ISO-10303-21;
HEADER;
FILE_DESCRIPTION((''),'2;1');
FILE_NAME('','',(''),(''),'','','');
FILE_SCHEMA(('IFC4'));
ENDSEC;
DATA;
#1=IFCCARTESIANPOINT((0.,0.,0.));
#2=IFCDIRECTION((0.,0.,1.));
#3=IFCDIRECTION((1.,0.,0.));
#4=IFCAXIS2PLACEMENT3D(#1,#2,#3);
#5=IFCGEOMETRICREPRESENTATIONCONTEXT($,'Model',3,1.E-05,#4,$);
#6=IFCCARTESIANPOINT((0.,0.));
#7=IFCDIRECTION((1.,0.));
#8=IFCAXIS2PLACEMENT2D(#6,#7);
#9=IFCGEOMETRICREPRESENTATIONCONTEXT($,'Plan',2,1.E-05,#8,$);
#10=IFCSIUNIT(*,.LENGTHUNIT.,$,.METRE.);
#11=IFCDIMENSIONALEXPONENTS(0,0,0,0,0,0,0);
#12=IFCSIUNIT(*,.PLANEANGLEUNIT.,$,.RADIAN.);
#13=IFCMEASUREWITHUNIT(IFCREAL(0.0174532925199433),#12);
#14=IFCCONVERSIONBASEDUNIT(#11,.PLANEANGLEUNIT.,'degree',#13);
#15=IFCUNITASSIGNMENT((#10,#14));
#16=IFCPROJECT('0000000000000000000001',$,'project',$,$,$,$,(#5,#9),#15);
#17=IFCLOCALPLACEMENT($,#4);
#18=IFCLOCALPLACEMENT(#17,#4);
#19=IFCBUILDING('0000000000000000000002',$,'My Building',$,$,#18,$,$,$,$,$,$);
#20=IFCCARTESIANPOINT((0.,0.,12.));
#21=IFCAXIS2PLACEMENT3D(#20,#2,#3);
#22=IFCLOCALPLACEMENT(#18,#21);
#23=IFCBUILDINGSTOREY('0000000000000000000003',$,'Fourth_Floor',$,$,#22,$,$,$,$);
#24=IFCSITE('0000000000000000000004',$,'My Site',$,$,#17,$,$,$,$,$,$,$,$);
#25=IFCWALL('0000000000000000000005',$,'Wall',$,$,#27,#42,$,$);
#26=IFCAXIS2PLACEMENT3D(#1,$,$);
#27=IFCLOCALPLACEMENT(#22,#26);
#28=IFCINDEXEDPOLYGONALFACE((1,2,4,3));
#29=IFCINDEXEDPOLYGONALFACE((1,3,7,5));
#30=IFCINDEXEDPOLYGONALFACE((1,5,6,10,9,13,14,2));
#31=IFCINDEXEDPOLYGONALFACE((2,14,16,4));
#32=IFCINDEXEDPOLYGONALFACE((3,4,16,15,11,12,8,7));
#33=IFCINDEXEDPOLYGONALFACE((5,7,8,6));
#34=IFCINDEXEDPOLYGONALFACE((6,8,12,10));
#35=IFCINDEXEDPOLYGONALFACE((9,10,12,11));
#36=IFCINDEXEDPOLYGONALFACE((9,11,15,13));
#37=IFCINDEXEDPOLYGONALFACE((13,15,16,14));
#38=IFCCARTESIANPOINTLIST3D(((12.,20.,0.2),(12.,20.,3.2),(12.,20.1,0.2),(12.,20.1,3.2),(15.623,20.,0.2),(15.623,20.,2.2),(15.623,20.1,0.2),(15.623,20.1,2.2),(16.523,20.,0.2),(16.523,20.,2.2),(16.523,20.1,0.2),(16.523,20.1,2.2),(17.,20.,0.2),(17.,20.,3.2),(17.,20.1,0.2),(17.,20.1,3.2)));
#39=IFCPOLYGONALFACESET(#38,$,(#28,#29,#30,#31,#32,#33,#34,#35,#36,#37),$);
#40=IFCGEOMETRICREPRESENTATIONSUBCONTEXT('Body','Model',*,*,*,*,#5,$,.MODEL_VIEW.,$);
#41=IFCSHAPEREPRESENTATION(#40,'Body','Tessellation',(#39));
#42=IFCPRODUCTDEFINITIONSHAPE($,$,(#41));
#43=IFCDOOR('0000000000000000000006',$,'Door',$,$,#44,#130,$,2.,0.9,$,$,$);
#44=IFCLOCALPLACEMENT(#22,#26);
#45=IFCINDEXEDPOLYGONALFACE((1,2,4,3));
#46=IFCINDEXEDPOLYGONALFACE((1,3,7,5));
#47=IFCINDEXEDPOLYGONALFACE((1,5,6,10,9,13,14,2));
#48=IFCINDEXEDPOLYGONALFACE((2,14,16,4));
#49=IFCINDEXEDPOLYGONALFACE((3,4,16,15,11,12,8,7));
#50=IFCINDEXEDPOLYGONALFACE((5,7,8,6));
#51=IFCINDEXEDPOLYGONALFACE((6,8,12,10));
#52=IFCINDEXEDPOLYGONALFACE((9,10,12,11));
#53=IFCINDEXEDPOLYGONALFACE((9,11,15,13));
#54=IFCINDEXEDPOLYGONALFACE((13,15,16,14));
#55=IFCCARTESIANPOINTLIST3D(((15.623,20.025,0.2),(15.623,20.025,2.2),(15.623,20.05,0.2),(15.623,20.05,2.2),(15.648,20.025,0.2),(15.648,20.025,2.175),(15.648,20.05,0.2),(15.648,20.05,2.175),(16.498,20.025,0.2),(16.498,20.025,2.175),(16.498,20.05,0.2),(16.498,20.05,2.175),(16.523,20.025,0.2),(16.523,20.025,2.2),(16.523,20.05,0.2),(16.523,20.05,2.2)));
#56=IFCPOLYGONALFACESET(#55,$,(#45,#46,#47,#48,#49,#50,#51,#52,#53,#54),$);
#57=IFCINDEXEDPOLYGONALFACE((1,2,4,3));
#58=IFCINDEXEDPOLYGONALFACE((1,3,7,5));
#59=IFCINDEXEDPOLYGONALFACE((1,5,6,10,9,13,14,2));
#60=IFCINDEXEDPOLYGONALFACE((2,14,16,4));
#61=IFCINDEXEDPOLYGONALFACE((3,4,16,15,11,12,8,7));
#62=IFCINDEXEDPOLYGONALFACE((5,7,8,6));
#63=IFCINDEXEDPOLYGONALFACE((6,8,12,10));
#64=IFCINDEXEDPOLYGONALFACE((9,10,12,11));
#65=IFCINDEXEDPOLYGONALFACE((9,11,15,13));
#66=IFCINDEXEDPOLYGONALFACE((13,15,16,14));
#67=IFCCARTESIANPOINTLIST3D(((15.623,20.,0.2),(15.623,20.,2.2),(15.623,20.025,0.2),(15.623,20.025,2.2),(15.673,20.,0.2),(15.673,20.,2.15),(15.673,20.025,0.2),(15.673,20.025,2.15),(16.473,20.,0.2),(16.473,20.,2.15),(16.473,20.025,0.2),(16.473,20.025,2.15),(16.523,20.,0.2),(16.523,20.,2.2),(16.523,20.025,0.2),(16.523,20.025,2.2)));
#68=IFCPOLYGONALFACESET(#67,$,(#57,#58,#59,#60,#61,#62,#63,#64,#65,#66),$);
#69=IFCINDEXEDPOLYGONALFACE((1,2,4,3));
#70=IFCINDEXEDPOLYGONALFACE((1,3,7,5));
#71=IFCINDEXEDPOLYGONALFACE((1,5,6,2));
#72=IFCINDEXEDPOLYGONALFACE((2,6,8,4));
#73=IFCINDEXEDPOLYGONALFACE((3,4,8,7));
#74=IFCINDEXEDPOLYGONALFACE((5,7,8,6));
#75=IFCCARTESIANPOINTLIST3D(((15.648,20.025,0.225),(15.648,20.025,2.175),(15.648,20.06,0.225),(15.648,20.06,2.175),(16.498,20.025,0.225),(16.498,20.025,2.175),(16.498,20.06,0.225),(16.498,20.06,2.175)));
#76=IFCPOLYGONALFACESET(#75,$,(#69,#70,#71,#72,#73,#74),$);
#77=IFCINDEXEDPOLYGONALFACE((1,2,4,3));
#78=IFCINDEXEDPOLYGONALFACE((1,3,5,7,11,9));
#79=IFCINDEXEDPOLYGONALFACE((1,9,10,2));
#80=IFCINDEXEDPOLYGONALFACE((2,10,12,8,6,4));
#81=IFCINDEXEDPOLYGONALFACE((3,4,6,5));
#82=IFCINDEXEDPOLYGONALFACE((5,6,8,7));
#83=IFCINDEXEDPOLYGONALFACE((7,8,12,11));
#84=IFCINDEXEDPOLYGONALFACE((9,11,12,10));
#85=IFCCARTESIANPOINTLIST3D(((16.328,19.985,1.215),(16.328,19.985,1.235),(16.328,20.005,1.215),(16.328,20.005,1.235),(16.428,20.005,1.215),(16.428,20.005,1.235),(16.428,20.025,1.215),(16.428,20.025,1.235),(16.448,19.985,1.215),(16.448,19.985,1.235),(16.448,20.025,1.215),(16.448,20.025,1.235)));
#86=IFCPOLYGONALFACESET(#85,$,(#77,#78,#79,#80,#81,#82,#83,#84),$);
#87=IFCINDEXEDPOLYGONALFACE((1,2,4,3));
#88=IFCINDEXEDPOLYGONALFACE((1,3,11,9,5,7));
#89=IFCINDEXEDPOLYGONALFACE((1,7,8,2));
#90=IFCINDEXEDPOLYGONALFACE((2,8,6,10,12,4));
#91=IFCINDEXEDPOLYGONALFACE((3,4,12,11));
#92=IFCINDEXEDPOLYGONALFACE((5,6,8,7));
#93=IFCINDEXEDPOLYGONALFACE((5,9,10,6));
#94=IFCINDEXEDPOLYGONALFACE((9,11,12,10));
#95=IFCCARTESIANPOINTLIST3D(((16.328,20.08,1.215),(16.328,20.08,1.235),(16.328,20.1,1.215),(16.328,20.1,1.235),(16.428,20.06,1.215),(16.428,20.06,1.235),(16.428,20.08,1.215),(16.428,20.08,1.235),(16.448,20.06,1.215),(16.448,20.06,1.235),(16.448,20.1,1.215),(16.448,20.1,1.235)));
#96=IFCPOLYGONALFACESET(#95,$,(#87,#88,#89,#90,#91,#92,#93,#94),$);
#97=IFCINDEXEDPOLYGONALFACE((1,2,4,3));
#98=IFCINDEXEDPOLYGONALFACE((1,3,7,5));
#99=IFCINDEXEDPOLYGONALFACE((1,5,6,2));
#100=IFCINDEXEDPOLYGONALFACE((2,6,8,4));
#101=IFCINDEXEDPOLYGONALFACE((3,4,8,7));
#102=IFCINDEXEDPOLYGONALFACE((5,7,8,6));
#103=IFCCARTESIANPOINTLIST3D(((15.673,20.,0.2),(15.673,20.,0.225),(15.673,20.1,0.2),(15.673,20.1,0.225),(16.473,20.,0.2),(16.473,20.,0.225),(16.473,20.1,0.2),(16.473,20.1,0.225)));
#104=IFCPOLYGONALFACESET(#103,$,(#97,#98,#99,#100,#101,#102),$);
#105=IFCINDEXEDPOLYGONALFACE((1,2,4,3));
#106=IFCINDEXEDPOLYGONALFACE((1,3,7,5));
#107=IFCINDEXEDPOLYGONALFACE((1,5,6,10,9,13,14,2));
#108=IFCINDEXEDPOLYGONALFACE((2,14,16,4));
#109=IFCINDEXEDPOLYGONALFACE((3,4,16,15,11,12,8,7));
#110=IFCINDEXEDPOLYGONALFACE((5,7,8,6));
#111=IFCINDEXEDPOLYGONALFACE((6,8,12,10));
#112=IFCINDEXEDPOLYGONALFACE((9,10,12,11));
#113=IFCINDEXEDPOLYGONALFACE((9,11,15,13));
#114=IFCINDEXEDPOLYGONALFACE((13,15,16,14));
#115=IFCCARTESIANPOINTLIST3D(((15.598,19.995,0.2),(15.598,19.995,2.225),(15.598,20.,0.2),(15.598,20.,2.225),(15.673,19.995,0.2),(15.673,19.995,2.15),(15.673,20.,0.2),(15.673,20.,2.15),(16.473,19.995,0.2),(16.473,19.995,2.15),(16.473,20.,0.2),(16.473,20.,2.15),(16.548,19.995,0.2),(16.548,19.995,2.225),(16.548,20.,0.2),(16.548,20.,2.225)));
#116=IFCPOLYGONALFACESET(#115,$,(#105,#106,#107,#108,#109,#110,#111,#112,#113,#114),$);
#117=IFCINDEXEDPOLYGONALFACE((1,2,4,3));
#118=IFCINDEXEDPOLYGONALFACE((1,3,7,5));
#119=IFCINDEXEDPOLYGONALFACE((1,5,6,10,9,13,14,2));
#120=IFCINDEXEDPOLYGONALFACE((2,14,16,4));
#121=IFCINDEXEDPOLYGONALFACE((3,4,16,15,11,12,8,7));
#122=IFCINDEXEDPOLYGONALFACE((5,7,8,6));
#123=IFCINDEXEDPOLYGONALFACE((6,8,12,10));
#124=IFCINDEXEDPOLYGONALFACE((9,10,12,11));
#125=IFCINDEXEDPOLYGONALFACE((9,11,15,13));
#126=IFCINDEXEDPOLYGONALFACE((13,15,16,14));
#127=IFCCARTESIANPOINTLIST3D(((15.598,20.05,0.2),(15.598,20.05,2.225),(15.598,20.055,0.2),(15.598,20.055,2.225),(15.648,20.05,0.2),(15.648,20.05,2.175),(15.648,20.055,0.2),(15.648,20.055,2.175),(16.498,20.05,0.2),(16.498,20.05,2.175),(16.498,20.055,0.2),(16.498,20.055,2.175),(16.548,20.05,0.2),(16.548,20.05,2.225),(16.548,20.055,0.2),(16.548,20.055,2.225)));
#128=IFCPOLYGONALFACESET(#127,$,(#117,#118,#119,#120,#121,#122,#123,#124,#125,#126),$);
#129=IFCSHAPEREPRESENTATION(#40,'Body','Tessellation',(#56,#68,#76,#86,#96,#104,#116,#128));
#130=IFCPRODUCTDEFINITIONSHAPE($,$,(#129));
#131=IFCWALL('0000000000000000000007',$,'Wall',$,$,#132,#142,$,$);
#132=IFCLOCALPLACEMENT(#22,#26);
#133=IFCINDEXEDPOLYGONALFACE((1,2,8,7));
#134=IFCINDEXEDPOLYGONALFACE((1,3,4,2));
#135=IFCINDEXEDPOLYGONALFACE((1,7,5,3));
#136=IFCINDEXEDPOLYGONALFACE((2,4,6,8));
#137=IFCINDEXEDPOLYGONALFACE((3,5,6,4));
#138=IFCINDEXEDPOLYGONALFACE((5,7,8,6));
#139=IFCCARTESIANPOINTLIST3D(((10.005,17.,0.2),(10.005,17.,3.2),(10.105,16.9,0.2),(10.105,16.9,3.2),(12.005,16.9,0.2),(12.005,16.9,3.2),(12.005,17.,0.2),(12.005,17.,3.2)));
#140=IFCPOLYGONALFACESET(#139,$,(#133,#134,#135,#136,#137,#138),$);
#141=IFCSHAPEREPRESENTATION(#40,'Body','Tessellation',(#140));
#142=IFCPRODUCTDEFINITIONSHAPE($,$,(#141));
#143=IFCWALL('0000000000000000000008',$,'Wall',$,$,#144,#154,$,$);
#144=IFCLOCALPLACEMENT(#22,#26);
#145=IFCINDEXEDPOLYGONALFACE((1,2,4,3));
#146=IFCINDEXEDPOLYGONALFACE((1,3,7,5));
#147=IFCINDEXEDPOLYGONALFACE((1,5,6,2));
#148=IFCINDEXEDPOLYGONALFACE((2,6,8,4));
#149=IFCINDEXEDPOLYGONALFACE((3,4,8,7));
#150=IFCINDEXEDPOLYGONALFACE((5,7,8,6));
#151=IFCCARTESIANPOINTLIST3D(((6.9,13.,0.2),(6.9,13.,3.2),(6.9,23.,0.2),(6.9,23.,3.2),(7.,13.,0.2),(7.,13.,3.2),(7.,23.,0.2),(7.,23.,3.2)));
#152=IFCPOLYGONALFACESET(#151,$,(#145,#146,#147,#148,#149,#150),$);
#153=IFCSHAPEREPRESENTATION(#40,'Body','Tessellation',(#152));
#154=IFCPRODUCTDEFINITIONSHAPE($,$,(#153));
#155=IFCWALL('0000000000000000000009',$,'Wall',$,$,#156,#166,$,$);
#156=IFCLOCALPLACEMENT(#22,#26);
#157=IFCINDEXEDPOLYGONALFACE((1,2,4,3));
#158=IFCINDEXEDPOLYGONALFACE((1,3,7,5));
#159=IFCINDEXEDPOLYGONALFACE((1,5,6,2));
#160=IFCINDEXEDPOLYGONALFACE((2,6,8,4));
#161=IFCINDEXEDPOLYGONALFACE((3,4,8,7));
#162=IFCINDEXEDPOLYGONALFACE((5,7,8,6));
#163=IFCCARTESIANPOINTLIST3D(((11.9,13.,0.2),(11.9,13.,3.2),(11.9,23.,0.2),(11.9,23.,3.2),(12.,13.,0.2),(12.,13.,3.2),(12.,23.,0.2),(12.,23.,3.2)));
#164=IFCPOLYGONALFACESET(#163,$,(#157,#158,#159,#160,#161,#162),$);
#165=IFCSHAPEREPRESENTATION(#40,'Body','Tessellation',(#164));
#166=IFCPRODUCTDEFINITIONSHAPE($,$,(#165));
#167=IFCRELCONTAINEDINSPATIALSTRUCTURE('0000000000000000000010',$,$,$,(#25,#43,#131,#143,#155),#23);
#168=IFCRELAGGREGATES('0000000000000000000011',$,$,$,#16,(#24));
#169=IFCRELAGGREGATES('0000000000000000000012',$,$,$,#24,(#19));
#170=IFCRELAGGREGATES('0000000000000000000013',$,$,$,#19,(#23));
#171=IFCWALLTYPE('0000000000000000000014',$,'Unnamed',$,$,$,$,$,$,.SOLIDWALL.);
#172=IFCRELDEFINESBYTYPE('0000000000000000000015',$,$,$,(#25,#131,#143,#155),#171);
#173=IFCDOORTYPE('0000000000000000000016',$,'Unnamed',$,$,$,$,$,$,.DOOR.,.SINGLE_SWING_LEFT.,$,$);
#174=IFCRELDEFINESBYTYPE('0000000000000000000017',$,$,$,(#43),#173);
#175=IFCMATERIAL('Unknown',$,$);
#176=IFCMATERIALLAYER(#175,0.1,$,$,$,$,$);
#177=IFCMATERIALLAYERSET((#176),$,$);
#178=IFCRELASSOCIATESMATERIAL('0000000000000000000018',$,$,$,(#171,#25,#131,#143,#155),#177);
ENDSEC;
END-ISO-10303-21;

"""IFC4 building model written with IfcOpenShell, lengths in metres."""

from ifc_helpers import new_model, entity, si_unit, converted_unit, frame, origin_with_axes, origin_2d_with_axis, place, context, subcontext, project, spatial, line, indexed_curve, outline, extrude, shape, source, transform, mapped, material, layer, layer_set, layer_usage, type_object, type_shapes, element, fill, save


model = new_model("IFC4")

# Units and contexts
model_context = context("Model", 3, precision=1e-05, world=origin_with_axes())
plan_context = context("Plan", 2, precision=1e-05, world=origin_2d_with_axis())
body_context_1 = subcontext(model_context, "Body", "Model", "MODEL_VIEW")
body_context_2 = subcontext(plan_context, "Body", "Plan", "PLAN_VIEW")
ifc_project = project(units=[si_unit("LENGTHUNIT", "METRE"), converted_unit("PLANEANGLEUNIT", "degree", entity("IfcReal", 0.0174532925199433), si_unit("PLANEANGLEUNIT", "RADIAN"), dimensions=[0, 0, 0, 0, 0, 0, 0])], contexts=[model_context, plan_context])

# Site, building, storey
site_placement = place(None, origin_with_axes())
site = spatial("IfcSite", under=ifc_project, at=site_placement, Name="My Site")
building_placement = place(site_placement, origin_with_axes())
building = spatial("IfcBuilding", under=site, at=building_placement, Name="My Building")
storey_placement = place(building_placement, frame((0.0, 0.0, 12.0), z_axis=(0.0, 0.0, 1.0), x_axis=(1.0, 0.0, 0.0)))
storey = spatial("IfcBuildingStorey", under=building, at=storey_placement, Name="Fourth_Floor")

# Wall, opening, door
ifc_material = material(Name="Unknown")
ifc_layer = layer(ifc_material, 0.1)
ifc_layer_set = layer_set([ifc_layer])
ifc_layer_usage_1 = layer_usage(ifc_layer_set, "AXIS2", "POSITIVE", 0.0)
wall_type = type_object("IfcWallType", Name="Unnamed", PredefinedType="SOLIDWALL", material=ifc_layer_set)
wall_1_placement = place(storey_placement, frame((12.0, 20.0, 0.2), z_axis=(0.0, 0.0, 1.0), x_axis=(1.0, 0.0, 0.0)))
wall_1 = element("IfcWall", 1, at=wall_1_placement, inside=storey, type_object=wall_type, material=ifc_layer_usage_1, Name="Wall", context=body_context_1, shape_type="SweptSolid", body=[
    extrude(outline(indexed_curve([(0.0, 0.0), (0.0, 0.1), (5.0, 0.1), (5.0, 0.0)], segments=[line(1, 2, 3, 4, 1)])), origin_with_axes(), (0.0, 0.0, 1.0), 3.0),
])
shared_shape_1 = source(origin_with_axes(), body_context_1, "Body", "SweptSolid", [
    extrude(outline(indexed_curve([(0.0, 0.0), (0.9, 0.0), (0.9, 2.0), (0.0, 2.0)], segments=[line(1, 2, 3, 4, 1)])), frame((0.0, -0.6, 0.0), z_axis=(0.0, -1.0, 0.0), x_axis=(1.0, 0.0, 0.0)), (0.0, 0.0, -1.0), 1.2),
])
opening_1_placement = place(wall_1_placement, frame((3.623, 0.0, 0.0), z_axis=(0.0, 0.0, 1.0), x_axis=(1.0, 0.0, 0.0)))
opening_1 = element("IfcOpeningElement", 2, at=opening_1_placement, cuts=wall_1, PredefinedType="OPENING", context=body_context_1, shape_type="MappedRepresentation", body=[
    mapped(shared_shape_1, transform((0.0, 0.0, 0.0), x_axis=(1.0, 0.0, 0.0), y_axis=(0.0, 1.0, 0.0), z_axis=(0.0, 0.0, 1.0), scale=1.0)),
])
door_type = type_object("IfcDoorType", Name="Unnamed", OperationType="SINGLE_SWING_LEFT", PredefinedType="DOOR")
shared_shape_2 = source(origin_with_axes(), body_context_1, "Body", "SweptSolid", [
    extrude(outline(indexed_curve([(0.0, 0.0), (0.0, 2.0), (0.9, 2.0), (0.9, 0.0), (0.875, 0.0), (0.875, 1.975), (0.025, 1.975), (0.025, 0.0)], segments=[line(1, 2, 3, 4, 5, 6, 7, 8, 1)])), frame((0.0, 0.025, 0.0), z_axis=(0.0, -1.0, 0.0), x_axis=(1.0, 0.0, 0.0)), (0.0, 0.0, -1.0), 0.025),
    extrude(outline(indexed_curve([(0.0, 0.0), (0.0, 2.0), (0.9, 2.0), (0.9, 0.0), (0.85, 0.0), (0.85, 1.95), (0.05, 1.95), (0.05, 0.0)], segments=[line(1, 2, 3, 4, 5, 6, 7, 8, 1)])), frame((0.0, 0.0, 0.0), z_axis=(0.0, -1.0, 0.0), x_axis=(1.0, 0.0, 0.0)), (0.0, 0.0, -1.0), 0.025),
    extrude(outline(indexed_curve([(0.0, 0.0), (0.85, 0.0), (0.85, 0.035), (0.0, 0.035)], segments=[line(1, 2, 3, 4, 1)])), frame((0.025, 0.025, 0.025), z_axis=(0.0, 0.0, 1.0), x_axis=(1.0, 0.0, 0.0)), (0.0, 0.0, 1.0), 1.95),
    extrude(outline(indexed_curve([(0.0, 0.0), (0.0, -0.04), (-0.12, -0.04), (-0.12, -0.02), (-0.02, -0.02), (-0.02, 0.0)], segments=[line(1, 2, 3, 4, 5, 6, 1)])), frame((0.825, 0.025, 1.015), z_axis=(0.0, 0.0, 1.0), x_axis=(1.0, 0.0, 0.0)), (0.0, 0.0, 1.0), 0.02),
    extrude(outline(indexed_curve([(0.0, 0.0), (0.0, 0.04), (-0.12, 0.04), (-0.12, 0.02), (-0.02, 0.02), (-0.02, 0.0)], segments=[line(1, 2, 3, 4, 5, 6, 1)])), frame((0.825, 0.06, 1.015), z_axis=(0.0, 0.0, 1.0), x_axis=(1.0, 0.0, 0.0)), (0.0, 0.0, 1.0), 0.02),
    extrude(outline(indexed_curve([(0.0, 0.0), (0.8, 0.0), (0.8, 0.1), (0.0, 0.1)], segments=[line(1, 2, 3, 4, 1)])), frame((0.05, 0.0, 0.0), z_axis=(0.0, 0.0, 1.0), x_axis=(1.0, 0.0, 0.0)), (0.0, 0.0, 1.0), 0.025),
    extrude(outline(indexed_curve([(0.0, 0.0), (0.0, 2.025), (0.95, 2.025), (0.95, 0.0), (0.875, 0.0), (0.875, 1.95), (0.075, 1.95), (0.075, 0.0)], segments=[line(1, 2, 3, 4, 5, 6, 7, 8, 1)])), frame((-0.025, -0.005, 0.0), z_axis=(0.0, -1.0, 0.0), x_axis=(1.0, 0.0, 0.0)), (0.0, 0.0, -1.0), 0.005),
    extrude(outline(indexed_curve([(0.0, 0.0), (0.0, 2.025), (0.95, 2.025), (0.95, 0.0), (0.9, 0.0), (0.9, 1.975), (0.05, 1.975), (0.05, 0.0)], segments=[line(1, 2, 3, 4, 5, 6, 7, 8, 1)])), frame((-0.025, 0.05, 0.0), z_axis=(0.0, -1.0, 0.0), x_axis=(1.0, 0.0, 0.0)), (0.0, 0.0, -1.0), 0.005),
])
shared_shape_3 = source(origin_with_axes(), body_context_2, "Body", "Curve2D", [
    entity("IfcIndexedPolyCurve", entity("IfcCartesianPointList2D", [[0.0, 0.0], [0.0, 0.05], [0.025, 0.05], [0.025, 0.025], [0.05, 0.025], [0.05, 0.0]]), [entity("IfcLineIndex", [1, 2, 3, 4, 5, 6, 1])]),
    entity("IfcIndexedPolyCurve", entity("IfcCartesianPointList2D", [[0.9, 0.0], [0.9, 0.05], [0.875, 0.05], [0.875, 0.025], [0.85, 0.025], [0.85, 0.0]]), [entity("IfcLineIndex", [1, 2, 3, 4, 5, 6, 1])]),
    entity("IfcTrimmedCurve", entity("IfcEllipse", entity("IfcAxis2Placement2D", entity("IfcCartesianPoint", [0.06, 0.05]), entity("IfcDirection", [1.0, 0.0])), 0.815, 0.85), [entity("IfcCartesianPoint", [0.875, 0.05])], [entity("IfcCartesianPoint", [0.06, 0.9])], True, "CARTESIAN"),
    entity("IfcIndexedPolyCurve", entity("IfcCartesianPointList2D", [[0.025, 0.05], [0.06, 0.05], [0.06, 0.9], [0.025, 0.9]]), [entity("IfcLineIndex", [1, 2, 3, 4, 1])]),
])
type_shapes(door_type, [shared_shape_2, shared_shape_3])
door_1_placement = place(opening_1_placement, origin_with_axes())
door_1 = element("IfcDoor", 3, at=door_1_placement, inside=storey, type_object=door_type, Name="Door", OverallHeight=2.0, OverallWidth=0.9, shapes=[
    shape(body_context_1, "Body", "MappedRepresentation", [mapped(shared_shape_2, transform((0.0, 0.0, 0.0), x_axis=(1.0, 0.0, 0.0), y_axis=(0.0, 1.0, 0.0), z_axis=(0.0, 0.0, 1.0), scale=1.0))]),
    shape(body_context_2, "Body", "MappedRepresentation", [mapped(shared_shape_3, transform((0.0, 0.0, 0.0), x_axis=(1.0, 0.0, 0.0), y_axis=(0.0, 1.0, 0.0), z_axis=(0.0, 0.0, 1.0), scale=1.0))]),
])
fill(opening_1, door_1)

# Walls
ifc_layer_usage_2 = layer_usage(ifc_layer_set, "AXIS2", "POSITIVE", 0.0)
wall_2_placement = place(storey_placement, frame((12.005, 17.0, 0.2), z_axis=(0.0, 0.0, 1.0), x_axis=(-1.0, 0.0, 0.0)))
element("IfcWall", 4, at=wall_2_placement, inside=storey, type_object=wall_type, material=ifc_layer_usage_2, Name="Wall", context=body_context_1, shape_type="SweptSolid", body=[
    extrude(outline(indexed_curve([(0.0, 0.0), (0.0, 0.1), (1.9, 0.1), (2.0, 0.0)], segments=[line(1, 2, 3, 4, 1)])), origin_with_axes(), (0.0, 0.0, 1.0), 3.0),
])
ifc_layer_usage_3 = layer_usage(ifc_layer_set, "AXIS2", "POSITIVE", 0.0)
wall_3_placement = place(storey_placement, frame((6.9, 23.0, 0.2), z_axis=(0.0, 0.0, 1.0), x_axis=(0.0, -1.0, 0.0)))
element("IfcWall", 5, at=wall_3_placement, inside=storey, type_object=wall_type, material=ifc_layer_usage_3, Name="Wall", context=body_context_1, shape_type="SweptSolid", body=[
    extrude(outline(indexed_curve([(0.0, 0.0), (0.0, 0.1), (10.0, 0.1), (10.0, 0.0)], segments=[line(1, 2, 3, 4, 1)])), origin_with_axes(), (0.0, 0.0, 1.0), 3.0),
])
ifc_layer_usage_4 = layer_usage(ifc_layer_set, "AXIS2", "POSITIVE", 0.0)
wall_4_placement = place(storey_placement, frame((11.9, 23.0, 0.2), z_axis=(0.0, 0.0, 1.0), x_axis=(0.0, -1.0, 0.0)))
element("IfcWall", 6, at=wall_4_placement, inside=storey, type_object=wall_type, material=ifc_layer_usage_4, Name="Wall", context=body_context_1, shape_type="SweptSolid", body=[
    extrude(outline(indexed_curve([(0.0, 0.0), (0.0, 0.1), (10.0, 0.1), (10.0, 0.0)], segments=[line(1, 2, 3, 4, 1)])), origin_with_axes(), (0.0, 0.0, 1.0), 3.0),
])

save(model, "model.ifc")
